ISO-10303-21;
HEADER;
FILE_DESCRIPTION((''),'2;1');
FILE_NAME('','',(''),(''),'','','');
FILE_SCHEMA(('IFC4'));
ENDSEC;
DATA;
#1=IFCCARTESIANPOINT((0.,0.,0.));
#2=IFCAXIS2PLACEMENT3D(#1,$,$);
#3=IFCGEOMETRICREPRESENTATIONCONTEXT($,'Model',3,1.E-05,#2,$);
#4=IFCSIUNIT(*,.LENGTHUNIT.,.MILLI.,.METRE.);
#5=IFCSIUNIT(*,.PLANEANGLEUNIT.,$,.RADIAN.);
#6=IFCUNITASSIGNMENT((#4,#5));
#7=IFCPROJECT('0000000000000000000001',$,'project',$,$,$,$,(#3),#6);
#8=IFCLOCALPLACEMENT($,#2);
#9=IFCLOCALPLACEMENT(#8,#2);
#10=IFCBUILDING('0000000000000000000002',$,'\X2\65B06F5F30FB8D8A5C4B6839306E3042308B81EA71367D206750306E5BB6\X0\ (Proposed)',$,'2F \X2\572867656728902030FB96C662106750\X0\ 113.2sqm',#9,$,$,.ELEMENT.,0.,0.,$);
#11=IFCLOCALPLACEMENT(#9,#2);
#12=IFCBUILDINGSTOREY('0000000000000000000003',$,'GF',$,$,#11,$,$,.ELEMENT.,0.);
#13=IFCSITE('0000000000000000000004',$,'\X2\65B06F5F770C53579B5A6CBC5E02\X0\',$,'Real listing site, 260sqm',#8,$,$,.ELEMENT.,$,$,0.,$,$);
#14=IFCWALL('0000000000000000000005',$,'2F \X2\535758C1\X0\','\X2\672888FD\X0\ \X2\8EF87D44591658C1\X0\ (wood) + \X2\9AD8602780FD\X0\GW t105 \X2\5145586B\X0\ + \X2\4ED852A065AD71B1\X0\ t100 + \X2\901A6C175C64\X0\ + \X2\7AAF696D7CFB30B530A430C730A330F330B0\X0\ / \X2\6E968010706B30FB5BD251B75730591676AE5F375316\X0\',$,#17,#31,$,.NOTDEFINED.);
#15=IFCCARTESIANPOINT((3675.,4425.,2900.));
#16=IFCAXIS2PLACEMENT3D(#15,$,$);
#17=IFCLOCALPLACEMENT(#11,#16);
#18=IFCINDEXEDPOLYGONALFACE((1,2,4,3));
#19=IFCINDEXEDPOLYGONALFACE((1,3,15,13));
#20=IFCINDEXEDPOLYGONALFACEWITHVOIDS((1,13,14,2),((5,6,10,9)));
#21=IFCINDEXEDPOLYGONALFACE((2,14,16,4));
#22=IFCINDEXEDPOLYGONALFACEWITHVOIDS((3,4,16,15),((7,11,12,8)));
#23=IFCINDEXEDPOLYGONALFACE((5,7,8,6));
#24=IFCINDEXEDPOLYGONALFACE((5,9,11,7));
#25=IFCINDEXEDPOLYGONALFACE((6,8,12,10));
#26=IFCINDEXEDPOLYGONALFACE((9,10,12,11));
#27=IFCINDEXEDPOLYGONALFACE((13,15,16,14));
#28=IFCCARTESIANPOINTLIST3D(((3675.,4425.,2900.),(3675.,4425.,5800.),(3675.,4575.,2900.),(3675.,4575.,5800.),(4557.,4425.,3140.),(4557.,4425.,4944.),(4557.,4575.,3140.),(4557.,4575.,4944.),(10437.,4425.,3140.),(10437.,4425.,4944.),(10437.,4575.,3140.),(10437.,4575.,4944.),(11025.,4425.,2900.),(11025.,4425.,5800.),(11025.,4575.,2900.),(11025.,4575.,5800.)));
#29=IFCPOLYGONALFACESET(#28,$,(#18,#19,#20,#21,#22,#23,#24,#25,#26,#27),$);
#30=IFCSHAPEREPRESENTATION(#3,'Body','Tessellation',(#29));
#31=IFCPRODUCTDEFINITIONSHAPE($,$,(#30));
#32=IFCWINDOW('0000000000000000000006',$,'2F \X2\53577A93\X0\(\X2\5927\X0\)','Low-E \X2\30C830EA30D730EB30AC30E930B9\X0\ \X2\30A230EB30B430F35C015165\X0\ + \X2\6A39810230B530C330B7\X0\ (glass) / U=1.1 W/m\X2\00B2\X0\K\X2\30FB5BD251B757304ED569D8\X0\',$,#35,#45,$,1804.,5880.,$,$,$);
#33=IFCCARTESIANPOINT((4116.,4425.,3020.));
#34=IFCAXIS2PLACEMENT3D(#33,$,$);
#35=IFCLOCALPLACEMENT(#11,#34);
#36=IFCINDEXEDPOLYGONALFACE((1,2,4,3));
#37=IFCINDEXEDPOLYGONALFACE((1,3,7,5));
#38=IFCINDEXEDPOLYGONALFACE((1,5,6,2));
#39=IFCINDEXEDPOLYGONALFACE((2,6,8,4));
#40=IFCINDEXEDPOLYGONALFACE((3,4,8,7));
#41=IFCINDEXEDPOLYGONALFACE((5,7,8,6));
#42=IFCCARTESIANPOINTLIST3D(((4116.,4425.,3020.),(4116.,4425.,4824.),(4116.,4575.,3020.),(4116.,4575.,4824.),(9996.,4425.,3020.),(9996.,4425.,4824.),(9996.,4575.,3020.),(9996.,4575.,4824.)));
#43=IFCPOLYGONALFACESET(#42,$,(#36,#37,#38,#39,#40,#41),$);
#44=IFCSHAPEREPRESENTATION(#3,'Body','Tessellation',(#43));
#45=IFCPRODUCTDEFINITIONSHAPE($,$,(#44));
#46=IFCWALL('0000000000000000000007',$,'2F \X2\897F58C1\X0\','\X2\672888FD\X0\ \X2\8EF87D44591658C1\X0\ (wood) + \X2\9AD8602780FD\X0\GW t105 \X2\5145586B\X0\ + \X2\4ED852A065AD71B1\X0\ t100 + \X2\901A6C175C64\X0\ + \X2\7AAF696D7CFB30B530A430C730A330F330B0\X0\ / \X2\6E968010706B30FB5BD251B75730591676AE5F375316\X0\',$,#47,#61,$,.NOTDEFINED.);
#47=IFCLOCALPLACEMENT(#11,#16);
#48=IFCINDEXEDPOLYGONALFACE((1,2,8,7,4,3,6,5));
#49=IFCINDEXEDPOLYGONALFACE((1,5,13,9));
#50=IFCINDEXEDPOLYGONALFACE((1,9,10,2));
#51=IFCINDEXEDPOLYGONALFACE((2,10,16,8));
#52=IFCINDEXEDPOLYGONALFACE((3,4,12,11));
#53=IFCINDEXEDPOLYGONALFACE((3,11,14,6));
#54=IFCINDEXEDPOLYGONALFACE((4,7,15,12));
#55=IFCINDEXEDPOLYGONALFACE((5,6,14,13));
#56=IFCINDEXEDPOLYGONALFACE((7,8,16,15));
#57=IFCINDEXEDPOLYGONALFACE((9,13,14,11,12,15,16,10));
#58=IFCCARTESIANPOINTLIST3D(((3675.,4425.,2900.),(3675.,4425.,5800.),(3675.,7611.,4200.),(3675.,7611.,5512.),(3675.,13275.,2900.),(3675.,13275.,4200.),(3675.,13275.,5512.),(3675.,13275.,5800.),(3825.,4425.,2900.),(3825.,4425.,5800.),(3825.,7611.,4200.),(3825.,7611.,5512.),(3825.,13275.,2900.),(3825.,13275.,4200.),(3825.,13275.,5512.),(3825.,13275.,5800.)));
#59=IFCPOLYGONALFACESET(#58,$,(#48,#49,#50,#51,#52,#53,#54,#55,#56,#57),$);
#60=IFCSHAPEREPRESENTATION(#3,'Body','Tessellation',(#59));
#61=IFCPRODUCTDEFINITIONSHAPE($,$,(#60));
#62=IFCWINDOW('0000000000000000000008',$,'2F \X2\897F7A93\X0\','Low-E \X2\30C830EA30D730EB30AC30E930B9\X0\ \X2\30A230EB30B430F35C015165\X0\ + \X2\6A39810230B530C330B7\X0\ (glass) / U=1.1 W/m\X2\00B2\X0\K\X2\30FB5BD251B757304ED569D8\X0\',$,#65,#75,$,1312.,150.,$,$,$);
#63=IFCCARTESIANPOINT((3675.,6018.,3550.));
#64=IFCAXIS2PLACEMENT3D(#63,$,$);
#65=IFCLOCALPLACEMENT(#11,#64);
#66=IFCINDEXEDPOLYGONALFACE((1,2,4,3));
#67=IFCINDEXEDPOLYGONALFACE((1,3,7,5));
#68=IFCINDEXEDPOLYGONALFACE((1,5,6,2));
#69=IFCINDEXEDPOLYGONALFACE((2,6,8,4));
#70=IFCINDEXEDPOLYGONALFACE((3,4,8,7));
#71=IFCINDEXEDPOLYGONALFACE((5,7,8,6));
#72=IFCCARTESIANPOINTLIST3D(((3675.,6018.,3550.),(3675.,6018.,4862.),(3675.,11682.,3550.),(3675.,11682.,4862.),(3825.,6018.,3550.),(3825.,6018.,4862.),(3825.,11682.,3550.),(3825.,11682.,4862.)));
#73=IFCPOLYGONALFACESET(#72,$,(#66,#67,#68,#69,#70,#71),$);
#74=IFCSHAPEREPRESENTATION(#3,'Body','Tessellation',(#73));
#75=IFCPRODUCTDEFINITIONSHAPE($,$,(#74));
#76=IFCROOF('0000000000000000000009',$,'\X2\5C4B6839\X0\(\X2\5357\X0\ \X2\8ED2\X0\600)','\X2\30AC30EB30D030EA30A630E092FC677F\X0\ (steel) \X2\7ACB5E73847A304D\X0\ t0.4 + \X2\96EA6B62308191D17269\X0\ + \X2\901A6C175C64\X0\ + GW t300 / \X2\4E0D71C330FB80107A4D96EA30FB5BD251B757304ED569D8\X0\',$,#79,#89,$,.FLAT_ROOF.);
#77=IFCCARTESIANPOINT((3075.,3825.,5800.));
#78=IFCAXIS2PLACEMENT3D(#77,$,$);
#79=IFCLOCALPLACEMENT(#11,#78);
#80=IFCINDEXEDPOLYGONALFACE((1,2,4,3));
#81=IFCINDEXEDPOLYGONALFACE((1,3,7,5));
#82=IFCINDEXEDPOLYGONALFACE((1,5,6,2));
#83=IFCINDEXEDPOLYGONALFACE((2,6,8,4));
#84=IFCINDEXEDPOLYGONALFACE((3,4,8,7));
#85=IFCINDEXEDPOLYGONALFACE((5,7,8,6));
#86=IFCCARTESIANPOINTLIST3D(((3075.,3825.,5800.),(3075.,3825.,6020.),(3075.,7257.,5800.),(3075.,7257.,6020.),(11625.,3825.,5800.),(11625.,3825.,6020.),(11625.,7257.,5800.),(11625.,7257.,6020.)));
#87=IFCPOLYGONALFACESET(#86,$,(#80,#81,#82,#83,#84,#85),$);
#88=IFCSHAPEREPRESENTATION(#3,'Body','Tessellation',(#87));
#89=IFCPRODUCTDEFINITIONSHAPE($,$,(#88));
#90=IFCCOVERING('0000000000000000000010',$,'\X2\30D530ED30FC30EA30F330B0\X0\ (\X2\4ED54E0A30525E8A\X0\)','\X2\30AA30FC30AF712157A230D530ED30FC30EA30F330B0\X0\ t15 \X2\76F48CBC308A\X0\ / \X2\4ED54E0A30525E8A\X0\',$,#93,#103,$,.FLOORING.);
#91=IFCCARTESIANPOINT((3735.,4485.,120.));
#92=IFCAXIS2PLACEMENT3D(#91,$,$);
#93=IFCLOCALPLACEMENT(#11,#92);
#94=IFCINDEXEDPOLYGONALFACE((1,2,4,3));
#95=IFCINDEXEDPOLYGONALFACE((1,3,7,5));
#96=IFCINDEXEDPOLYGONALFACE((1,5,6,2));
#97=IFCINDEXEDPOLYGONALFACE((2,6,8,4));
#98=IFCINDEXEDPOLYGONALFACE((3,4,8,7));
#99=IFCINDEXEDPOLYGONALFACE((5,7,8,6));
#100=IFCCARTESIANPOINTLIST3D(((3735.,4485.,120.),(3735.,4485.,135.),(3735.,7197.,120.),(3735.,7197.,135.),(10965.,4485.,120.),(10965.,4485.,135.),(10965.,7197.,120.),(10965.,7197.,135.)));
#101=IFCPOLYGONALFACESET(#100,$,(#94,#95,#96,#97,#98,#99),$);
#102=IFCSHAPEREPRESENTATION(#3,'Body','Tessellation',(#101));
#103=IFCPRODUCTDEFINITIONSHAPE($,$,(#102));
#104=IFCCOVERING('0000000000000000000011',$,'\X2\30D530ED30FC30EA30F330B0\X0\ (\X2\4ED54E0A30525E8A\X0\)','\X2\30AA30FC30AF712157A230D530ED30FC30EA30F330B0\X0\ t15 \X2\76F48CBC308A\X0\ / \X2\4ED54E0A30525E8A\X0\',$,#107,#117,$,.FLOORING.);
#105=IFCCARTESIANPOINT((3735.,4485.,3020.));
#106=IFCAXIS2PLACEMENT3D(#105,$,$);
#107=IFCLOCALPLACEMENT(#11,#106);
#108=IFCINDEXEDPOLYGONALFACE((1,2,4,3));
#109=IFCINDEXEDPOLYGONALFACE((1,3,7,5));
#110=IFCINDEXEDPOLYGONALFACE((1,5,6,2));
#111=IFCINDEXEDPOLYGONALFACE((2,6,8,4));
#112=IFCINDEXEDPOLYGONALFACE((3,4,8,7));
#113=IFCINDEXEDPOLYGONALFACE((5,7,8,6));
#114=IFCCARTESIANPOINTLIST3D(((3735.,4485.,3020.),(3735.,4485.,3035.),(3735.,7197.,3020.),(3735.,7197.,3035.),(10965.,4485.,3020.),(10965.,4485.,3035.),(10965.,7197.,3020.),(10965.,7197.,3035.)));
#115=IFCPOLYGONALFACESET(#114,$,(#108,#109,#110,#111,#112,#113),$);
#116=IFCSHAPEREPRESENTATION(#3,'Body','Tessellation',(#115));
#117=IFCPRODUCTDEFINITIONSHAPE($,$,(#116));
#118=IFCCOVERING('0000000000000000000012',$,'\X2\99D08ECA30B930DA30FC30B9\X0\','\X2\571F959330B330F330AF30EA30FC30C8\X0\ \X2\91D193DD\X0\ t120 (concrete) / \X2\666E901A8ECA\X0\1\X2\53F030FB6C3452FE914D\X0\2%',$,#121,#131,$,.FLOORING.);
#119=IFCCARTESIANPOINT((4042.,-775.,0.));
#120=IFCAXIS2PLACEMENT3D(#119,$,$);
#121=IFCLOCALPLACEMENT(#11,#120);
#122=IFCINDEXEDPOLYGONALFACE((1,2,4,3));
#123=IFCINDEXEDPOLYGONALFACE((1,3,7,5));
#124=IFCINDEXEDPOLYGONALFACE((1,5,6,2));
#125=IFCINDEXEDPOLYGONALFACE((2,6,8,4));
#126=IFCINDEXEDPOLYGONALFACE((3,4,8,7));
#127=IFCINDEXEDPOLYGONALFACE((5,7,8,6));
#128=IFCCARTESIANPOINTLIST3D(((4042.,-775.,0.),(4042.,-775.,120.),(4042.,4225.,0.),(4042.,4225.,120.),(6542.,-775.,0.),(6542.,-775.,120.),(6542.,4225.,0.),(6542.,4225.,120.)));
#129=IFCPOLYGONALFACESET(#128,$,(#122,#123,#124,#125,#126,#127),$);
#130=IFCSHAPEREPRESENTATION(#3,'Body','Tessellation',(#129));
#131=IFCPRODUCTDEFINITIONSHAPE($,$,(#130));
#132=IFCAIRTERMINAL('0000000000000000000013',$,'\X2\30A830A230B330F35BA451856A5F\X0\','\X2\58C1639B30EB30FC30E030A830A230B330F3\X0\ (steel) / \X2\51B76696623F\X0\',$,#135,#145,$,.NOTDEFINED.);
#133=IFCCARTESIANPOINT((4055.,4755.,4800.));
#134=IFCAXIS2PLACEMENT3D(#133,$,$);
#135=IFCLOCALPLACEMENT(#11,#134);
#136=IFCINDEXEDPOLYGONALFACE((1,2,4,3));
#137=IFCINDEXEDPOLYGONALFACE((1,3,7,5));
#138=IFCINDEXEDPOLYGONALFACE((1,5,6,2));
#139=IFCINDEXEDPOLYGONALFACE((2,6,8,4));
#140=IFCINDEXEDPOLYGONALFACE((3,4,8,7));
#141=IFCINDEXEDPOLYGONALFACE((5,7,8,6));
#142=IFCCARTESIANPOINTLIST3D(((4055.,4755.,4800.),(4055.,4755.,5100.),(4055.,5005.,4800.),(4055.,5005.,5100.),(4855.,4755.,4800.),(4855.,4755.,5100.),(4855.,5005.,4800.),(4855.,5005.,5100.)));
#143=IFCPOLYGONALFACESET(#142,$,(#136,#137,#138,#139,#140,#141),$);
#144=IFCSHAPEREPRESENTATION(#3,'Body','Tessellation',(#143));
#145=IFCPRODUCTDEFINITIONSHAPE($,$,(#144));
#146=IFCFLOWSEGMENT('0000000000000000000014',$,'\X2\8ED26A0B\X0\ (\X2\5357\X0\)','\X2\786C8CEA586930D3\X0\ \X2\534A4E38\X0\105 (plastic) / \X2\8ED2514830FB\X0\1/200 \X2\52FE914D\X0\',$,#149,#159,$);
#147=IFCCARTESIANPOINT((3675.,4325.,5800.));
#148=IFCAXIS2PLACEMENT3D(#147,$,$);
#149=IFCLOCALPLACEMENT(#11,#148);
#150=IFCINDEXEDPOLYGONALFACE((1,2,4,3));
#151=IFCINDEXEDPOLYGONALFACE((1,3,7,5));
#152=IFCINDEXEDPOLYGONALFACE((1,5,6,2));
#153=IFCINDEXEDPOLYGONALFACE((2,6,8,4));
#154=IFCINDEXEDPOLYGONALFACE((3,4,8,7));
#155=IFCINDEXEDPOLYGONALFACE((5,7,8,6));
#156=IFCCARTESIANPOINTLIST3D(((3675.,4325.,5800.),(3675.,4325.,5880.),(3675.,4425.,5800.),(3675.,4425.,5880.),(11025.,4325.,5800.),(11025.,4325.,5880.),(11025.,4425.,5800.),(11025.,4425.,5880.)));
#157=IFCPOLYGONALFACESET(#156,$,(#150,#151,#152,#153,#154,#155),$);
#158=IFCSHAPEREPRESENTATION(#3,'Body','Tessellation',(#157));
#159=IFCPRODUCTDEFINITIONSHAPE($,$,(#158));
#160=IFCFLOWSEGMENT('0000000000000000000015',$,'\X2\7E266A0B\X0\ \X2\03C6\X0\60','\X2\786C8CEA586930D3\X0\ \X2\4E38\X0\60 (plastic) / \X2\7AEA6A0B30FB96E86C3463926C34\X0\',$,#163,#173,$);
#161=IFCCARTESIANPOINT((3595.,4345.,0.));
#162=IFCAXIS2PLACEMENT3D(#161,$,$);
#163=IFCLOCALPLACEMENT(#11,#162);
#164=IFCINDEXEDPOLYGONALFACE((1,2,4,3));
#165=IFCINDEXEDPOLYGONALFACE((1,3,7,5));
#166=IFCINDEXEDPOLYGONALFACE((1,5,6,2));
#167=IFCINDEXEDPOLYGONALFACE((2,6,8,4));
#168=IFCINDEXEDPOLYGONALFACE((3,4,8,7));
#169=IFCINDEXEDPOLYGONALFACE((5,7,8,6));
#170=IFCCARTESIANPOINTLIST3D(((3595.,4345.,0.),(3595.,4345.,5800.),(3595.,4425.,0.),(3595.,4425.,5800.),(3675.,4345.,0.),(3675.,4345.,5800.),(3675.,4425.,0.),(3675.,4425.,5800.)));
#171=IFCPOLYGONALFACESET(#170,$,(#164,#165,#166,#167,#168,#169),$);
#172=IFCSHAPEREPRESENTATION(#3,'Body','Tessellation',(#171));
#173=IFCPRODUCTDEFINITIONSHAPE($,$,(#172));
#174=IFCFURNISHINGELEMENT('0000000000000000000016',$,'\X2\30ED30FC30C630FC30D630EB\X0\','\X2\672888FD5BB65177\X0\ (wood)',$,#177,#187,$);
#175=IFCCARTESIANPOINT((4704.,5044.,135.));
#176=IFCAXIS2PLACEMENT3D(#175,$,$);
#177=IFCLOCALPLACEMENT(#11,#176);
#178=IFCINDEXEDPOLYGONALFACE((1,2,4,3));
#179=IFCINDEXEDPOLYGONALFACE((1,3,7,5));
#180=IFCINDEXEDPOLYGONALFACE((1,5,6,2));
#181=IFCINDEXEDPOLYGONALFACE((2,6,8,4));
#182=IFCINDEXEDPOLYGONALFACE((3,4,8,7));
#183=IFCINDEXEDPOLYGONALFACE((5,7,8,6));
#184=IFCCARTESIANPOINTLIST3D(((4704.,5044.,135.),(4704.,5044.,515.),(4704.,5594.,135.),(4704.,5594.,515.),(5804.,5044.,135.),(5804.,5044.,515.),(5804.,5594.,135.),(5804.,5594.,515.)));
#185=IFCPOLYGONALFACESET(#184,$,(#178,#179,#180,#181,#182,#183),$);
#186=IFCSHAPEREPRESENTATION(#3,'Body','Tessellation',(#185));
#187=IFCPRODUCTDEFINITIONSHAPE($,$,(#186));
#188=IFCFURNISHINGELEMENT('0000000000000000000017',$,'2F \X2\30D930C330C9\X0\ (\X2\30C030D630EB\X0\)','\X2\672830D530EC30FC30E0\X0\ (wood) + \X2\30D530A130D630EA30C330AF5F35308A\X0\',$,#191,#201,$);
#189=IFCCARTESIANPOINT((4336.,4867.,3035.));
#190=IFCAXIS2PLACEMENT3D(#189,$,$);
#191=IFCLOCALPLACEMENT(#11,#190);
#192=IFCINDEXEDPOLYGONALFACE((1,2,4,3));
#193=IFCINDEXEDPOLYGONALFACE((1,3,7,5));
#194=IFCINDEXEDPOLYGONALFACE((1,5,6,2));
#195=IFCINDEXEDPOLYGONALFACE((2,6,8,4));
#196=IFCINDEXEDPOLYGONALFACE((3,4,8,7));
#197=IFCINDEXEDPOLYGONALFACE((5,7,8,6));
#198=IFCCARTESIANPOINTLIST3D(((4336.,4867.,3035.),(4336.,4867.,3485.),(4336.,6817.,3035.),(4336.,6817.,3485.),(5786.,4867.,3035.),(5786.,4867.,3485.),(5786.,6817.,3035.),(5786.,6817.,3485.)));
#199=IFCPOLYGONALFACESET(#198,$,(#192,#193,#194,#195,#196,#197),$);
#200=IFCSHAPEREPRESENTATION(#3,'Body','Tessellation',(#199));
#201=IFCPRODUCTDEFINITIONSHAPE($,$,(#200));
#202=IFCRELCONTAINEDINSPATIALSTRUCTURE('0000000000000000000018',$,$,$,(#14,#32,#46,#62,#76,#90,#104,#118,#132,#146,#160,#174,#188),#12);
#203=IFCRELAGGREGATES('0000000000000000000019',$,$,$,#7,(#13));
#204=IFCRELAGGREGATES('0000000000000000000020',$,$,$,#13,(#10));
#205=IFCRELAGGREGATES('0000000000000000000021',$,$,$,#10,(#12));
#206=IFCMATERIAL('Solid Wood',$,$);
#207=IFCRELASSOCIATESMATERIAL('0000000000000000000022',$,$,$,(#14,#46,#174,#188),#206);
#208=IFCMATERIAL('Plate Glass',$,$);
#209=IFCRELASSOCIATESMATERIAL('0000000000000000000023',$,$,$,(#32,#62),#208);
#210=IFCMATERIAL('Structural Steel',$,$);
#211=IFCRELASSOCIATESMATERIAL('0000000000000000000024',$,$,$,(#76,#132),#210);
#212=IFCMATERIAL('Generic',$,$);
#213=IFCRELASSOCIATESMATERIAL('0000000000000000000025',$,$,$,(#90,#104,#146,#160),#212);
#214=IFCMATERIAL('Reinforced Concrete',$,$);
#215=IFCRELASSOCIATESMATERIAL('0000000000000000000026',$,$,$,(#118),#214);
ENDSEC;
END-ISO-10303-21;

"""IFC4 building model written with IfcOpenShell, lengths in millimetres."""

from ifc_helpers import new_model, si_unit, frame, frame_2d, origin, place, context, project, spatial, rectangle, extrude, material, element, fill, save


model = new_model("IFC4")

# Units and contexts
model_context = context("Model", 3, precision=1e-05, world=origin())
ifc_project = project(units=[si_unit("LENGTHUNIT", "METRE", prefix="MILLI"), si_unit("PLANEANGLEUNIT", "RADIAN")], contexts=[model_context])

# Site, building, storey
site_placement = place(None, origin())
site = spatial("IfcSite", under=ifc_project, at=site_placement, Name="新潟県南魚沼市", ObjectType="Real listing site, 260sqm", CompositionType="ELEMENT", RefElevation=0.0)
building_placement = place(site_placement, origin())
building = spatial("IfcBuilding", under=site, at=building_placement, Name="新潟・越屋根のある自然素材の家 (Proposed)", ObjectType="2F 在来木造・集成材 113.2sqm", CompositionType="ELEMENT", ElevationOfRefHeight=0.0, ElevationOfTerrain=0.0)
storey_placement = place(building_placement, origin())
storey = spatial("IfcBuildingStorey", under=building, at=storey_placement, Name="GF", CompositionType="ELEMENT", Elevation=0.0)

# Shared definitions
ifc_material_1 = material(Name="Solid Wood")

# Shared definitions
ifc_material_2 = material(Name="Reinforced Concrete")

# Shared definitions
ifc_material_3 = material(Name="Plate Glass")

# Walls, openings, windows
wall_1_placement = place(storey_placement, frame((3675.0, 4425.0, 2900.0)))
wall_1 = element("IfcWall", 1, at=wall_1_placement, inside=storey, material=ifc_material_1, Name="2F 南壁", Description="木製 軸組外壁 (wood) + 高性能GW t105 充填 + 付加断熱 t100 + 通気層 + 窯業系サイディング / 準耐火・寒冷地外皮強化", PredefinedType="NOTDEFINED", context=model_context, shape_type="SweptSolid", body=[
    extrude(rectangle(XDim=7350.0, YDim=150.0, at=frame_2d((3675.0, 75.0))), frame((3675.0, 4425.0, 2900.0)), (0.0, 0.0, 1.0), 2900.0),
])
opening_1_placement = place(storey_placement, frame((4116.0, 4425.0, 3020.0)))
opening_1 = element("IfcOpeningElement", 2, at=opening_1_placement, cuts=wall_1, PredefinedType="NOTDEFINED", context=model_context, shape_type="SweptSolid", body=[
    extrude(rectangle(XDim=5880.0, YDim=150.0, at=frame_2d((2940.0, 75.0))), frame((4116.0, 4425.0, 3020.0)), (0.0, 0.0, 1.0), 1804.0),
])
window_1_placement = place(storey_placement, frame((4116.0, 4425.0, 3020.0)))
window_1 = element("IfcWindow", 3, at=window_1_placement, inside=storey, material=ifc_material_3, Name="2F 南窓(大)", Description="Low-E トリプルガラス アルゴン封入 + 樹脂サッシ (glass) / U=1.1 W/m²K・寒冷地仕様", OverallHeight=1804.0, OverallWidth=5880.0, context=model_context, shape_type="SweptSolid", body=[
    extrude(rectangle(XDim=5880.0, YDim=150.0, at=frame_2d((2940.0, 75.0))), frame((4116.0, 4425.0, 3020.0)), (0.0, 0.0, 1.0), 1804.0),
])
fill(opening_1, window_1)
wall_2_placement = place(storey_placement, frame((3675.0, 4425.0, 2900.0)))
wall_2 = element("IfcWall", 4, at=wall_2_placement, inside=storey, material=ifc_material_1, Name="2F 西壁", Description="木製 軸組外壁 (wood) + 高性能GW t105 充填 + 付加断熱 t100 + 通気層 + 窯業系サイディング / 準耐火・寒冷地外皮強化", PredefinedType="NOTDEFINED", context=model_context, shape_type="SweptSolid", body=[
    extrude(rectangle(XDim=150.0, YDim=8850.0, at=frame_2d((75.0, 4425.0))), frame((3675.0, 4425.0, 2900.0)), (0.0, 0.0, 1.0), 2900.0),
])
opening_2_placement = place(storey_placement, frame((3675.0, 6018.0, 3550.0)))
opening_2 = element("IfcOpeningElement", 5, at=opening_2_placement, cuts=wall_2, PredefinedType="NOTDEFINED", context=model_context, shape_type="SweptSolid", body=[
    extrude(rectangle(XDim=150.0, YDim=5664.0, at=frame_2d((75.0, 2832.0))), frame((3675.0, 6018.0, 3550.0)), (0.0, 0.0, 1.0), 1312.0),
])
window_2_placement = place(storey_placement, frame((3675.0, 6018.0, 3550.0)))
window_2 = element("IfcWindow", 6, at=window_2_placement, inside=storey, material=ifc_material_3, Name="2F 西窓", Description="Low-E トリプルガラス アルゴン封入 + 樹脂サッシ (glass) / U=1.1 W/m²K・寒冷地仕様", OverallHeight=1312.0, OverallWidth=150.0, context=model_context, shape_type="SweptSolid", body=[
    extrude(rectangle(XDim=150.0, YDim=5664.0, at=frame_2d((75.0, 2832.0))), frame((3675.0, 6018.0, 3550.0)), (0.0, 0.0, 1.0), 1312.0),
])
fill(opening_2, window_2)

# Roof
ifc_material_4 = material(Name="Structural Steel")
for number, where, name in (
    (7, (3075.0, 3825.0, 5800.0), "屋根(南 軒600)"),
):
    element("IfcRoof", number, at=place(storey_placement, frame(where)), inside=storey, material=ifc_material_4, Name=name, Description="ガルバリウム鋼板 (steel) 立平葺き t0.4 + 雪止め金物 + 通気層 + GW t300 / 不燃・耐積雪・寒冷地仕様", PredefinedType="FLAT_ROOF", context=model_context, shape_type="SweptSolid", body=[
        extrude(rectangle(XDim=8550.0, YDim=3432.0, at=frame_2d((4275.0, 1716.0))), frame((3075.0, 3825.0, 5800.0)), (0.0, 0.0, 1.0), 220.0),
    ])

# Coverings
ifc_material_5 = material(Name="Generic")
covering_1_placement = place(storey_placement, frame((3735.0, 4485.0, 120.0)))
element("IfcCovering", 8, at=covering_1_placement, inside=storey, material=ifc_material_5, Name="フローリング (仕上げ床)", Description="オーク無垢フローリング t15 直貼り / 仕上げ床", PredefinedType="FLOORING", context=model_context, shape_type="SweptSolid", body=[
    extrude(rectangle(XDim=7230.0, YDim=2712.0, at=frame_2d((3615.0, 1356.0))), frame((3735.0, 4485.0, 120.0)), (0.0, 0.0, 1.0), 15.0),
])
covering_2_placement = place(storey_placement, frame((3735.0, 4485.0, 3020.0)))
element("IfcCovering", 9, at=covering_2_placement, inside=storey, material=ifc_material_5, Name="フローリング (仕上げ床)", Description="オーク無垢フローリング t15 直貼り / 仕上げ床", PredefinedType="FLOORING", context=model_context, shape_type="SweptSolid", body=[
    extrude(rectangle(XDim=7230.0, YDim=2712.0, at=frame_2d((3615.0, 1356.0))), frame((3735.0, 4485.0, 3020.0)), (0.0, 0.0, 1.0), 15.0),
])
covering_3_placement = place(storey_placement, frame((4042.0, -775.0, 0.0)))
element("IfcCovering", 10, at=covering_3_placement, inside=storey, material=ifc_material_2, Name="駐車スペース", Description="土間コンクリート 金鏝 t120 (concrete) / 普通車1台・水勾配2%", PredefinedType="FLOORING", context=model_context, shape_type="SweptSolid", body=[
    extrude(rectangle(XDim=2500.0, YDim=5000.0, at=frame_2d((1250.0, 2500.0))), frame((4042.0, -775.0, 0.0)), (0.0, 0.0, 1.0), 120.0),
])

# Air terminal
air_terminal_placement = place(storey_placement, frame((4055.0, 4755.0, 4800.0)))
element("IfcAirTerminal", 11, at=air_terminal_placement, inside=storey, material=ifc_material_4, Name="エアコン室内機", Description="壁掛ルームエアコン (steel) / 冷暖房", PredefinedType="NOTDEFINED", context=model_context, shape_type="SweptSolid", body=[
    extrude(rectangle(XDim=800.0, YDim=250.0, at=frame_2d((400.0, 125.0))), frame((4055.0, 4755.0, 4800.0)), (0.0, 0.0, 1.0), 300.0),
])

# Flow segments
flow_segment_1_placement = place(storey_placement, frame((3675.0, 4325.0, 5800.0)))
element("IfcFlowSegment", 12, at=flow_segment_1_placement, inside=storey, material=ifc_material_5, Name="軒樋 (南)", Description="硬質塩ビ 半丸105 (plastic) / 軒先・1/200 勾配", context=model_context, shape_type="SweptSolid", body=[
    extrude(rectangle(XDim=7350.0, YDim=100.0, at=frame_2d((3675.0, 50.0))), frame((3675.0, 4325.0, 5800.0)), (0.0, 0.0, 1.0), 80.0),
])
flow_segment_2_placement = place(storey_placement, frame((3595.0, 4345.0, 0.0)))
element("IfcFlowSegment", 13, at=flow_segment_2_placement, inside=storey, material=ifc_material_5, Name="縦樋 φ60", Description="硬質塩ビ 丸60 (plastic) / 竪樋・雨水排水", context=model_context, shape_type="SweptSolid", body=[
    extrude(rectangle(XDim=80.0, YDim=80.0, at=frame_2d((40.0, 40.0))), frame((3595.0, 4345.0, 0.0)), (0.0, 0.0, 1.0), 5800.0),
])

# Furnishing elements
furnishing_1_placement = place(storey_placement, frame((4704.0, 5044.0, 135.0)))
element("IfcFurnishingElement", 14, at=furnishing_1_placement, inside=storey, material=ifc_material_1, Name="ローテーブル", Description="木製家具 (wood)", context=model_context, shape_type="SweptSolid", body=[
    extrude(rectangle(XDim=1100.0, YDim=550.0, at=frame_2d((550.0, 275.0))), frame((4704.0, 5044.0, 135.0)), (0.0, 0.0, 1.0), 380.0),
])
furnishing_2_placement = place(storey_placement, frame((4336.0, 4867.0, 3035.0)))
element("IfcFurnishingElement", 15, at=furnishing_2_placement, inside=storey, material=ifc_material_1, Name="2F ベッド (ダブル)", Description="木フレーム (wood) + ファブリック張り", context=model_context, shape_type="SweptSolid", body=[
    extrude(rectangle(XDim=1450.0, YDim=1950.0, at=frame_2d((725.0, 975.0))), frame((4336.0, 4867.0, 3035.0)), (0.0, 0.0, 1.0), 450.0),
])

save(model, "model.ifc")
